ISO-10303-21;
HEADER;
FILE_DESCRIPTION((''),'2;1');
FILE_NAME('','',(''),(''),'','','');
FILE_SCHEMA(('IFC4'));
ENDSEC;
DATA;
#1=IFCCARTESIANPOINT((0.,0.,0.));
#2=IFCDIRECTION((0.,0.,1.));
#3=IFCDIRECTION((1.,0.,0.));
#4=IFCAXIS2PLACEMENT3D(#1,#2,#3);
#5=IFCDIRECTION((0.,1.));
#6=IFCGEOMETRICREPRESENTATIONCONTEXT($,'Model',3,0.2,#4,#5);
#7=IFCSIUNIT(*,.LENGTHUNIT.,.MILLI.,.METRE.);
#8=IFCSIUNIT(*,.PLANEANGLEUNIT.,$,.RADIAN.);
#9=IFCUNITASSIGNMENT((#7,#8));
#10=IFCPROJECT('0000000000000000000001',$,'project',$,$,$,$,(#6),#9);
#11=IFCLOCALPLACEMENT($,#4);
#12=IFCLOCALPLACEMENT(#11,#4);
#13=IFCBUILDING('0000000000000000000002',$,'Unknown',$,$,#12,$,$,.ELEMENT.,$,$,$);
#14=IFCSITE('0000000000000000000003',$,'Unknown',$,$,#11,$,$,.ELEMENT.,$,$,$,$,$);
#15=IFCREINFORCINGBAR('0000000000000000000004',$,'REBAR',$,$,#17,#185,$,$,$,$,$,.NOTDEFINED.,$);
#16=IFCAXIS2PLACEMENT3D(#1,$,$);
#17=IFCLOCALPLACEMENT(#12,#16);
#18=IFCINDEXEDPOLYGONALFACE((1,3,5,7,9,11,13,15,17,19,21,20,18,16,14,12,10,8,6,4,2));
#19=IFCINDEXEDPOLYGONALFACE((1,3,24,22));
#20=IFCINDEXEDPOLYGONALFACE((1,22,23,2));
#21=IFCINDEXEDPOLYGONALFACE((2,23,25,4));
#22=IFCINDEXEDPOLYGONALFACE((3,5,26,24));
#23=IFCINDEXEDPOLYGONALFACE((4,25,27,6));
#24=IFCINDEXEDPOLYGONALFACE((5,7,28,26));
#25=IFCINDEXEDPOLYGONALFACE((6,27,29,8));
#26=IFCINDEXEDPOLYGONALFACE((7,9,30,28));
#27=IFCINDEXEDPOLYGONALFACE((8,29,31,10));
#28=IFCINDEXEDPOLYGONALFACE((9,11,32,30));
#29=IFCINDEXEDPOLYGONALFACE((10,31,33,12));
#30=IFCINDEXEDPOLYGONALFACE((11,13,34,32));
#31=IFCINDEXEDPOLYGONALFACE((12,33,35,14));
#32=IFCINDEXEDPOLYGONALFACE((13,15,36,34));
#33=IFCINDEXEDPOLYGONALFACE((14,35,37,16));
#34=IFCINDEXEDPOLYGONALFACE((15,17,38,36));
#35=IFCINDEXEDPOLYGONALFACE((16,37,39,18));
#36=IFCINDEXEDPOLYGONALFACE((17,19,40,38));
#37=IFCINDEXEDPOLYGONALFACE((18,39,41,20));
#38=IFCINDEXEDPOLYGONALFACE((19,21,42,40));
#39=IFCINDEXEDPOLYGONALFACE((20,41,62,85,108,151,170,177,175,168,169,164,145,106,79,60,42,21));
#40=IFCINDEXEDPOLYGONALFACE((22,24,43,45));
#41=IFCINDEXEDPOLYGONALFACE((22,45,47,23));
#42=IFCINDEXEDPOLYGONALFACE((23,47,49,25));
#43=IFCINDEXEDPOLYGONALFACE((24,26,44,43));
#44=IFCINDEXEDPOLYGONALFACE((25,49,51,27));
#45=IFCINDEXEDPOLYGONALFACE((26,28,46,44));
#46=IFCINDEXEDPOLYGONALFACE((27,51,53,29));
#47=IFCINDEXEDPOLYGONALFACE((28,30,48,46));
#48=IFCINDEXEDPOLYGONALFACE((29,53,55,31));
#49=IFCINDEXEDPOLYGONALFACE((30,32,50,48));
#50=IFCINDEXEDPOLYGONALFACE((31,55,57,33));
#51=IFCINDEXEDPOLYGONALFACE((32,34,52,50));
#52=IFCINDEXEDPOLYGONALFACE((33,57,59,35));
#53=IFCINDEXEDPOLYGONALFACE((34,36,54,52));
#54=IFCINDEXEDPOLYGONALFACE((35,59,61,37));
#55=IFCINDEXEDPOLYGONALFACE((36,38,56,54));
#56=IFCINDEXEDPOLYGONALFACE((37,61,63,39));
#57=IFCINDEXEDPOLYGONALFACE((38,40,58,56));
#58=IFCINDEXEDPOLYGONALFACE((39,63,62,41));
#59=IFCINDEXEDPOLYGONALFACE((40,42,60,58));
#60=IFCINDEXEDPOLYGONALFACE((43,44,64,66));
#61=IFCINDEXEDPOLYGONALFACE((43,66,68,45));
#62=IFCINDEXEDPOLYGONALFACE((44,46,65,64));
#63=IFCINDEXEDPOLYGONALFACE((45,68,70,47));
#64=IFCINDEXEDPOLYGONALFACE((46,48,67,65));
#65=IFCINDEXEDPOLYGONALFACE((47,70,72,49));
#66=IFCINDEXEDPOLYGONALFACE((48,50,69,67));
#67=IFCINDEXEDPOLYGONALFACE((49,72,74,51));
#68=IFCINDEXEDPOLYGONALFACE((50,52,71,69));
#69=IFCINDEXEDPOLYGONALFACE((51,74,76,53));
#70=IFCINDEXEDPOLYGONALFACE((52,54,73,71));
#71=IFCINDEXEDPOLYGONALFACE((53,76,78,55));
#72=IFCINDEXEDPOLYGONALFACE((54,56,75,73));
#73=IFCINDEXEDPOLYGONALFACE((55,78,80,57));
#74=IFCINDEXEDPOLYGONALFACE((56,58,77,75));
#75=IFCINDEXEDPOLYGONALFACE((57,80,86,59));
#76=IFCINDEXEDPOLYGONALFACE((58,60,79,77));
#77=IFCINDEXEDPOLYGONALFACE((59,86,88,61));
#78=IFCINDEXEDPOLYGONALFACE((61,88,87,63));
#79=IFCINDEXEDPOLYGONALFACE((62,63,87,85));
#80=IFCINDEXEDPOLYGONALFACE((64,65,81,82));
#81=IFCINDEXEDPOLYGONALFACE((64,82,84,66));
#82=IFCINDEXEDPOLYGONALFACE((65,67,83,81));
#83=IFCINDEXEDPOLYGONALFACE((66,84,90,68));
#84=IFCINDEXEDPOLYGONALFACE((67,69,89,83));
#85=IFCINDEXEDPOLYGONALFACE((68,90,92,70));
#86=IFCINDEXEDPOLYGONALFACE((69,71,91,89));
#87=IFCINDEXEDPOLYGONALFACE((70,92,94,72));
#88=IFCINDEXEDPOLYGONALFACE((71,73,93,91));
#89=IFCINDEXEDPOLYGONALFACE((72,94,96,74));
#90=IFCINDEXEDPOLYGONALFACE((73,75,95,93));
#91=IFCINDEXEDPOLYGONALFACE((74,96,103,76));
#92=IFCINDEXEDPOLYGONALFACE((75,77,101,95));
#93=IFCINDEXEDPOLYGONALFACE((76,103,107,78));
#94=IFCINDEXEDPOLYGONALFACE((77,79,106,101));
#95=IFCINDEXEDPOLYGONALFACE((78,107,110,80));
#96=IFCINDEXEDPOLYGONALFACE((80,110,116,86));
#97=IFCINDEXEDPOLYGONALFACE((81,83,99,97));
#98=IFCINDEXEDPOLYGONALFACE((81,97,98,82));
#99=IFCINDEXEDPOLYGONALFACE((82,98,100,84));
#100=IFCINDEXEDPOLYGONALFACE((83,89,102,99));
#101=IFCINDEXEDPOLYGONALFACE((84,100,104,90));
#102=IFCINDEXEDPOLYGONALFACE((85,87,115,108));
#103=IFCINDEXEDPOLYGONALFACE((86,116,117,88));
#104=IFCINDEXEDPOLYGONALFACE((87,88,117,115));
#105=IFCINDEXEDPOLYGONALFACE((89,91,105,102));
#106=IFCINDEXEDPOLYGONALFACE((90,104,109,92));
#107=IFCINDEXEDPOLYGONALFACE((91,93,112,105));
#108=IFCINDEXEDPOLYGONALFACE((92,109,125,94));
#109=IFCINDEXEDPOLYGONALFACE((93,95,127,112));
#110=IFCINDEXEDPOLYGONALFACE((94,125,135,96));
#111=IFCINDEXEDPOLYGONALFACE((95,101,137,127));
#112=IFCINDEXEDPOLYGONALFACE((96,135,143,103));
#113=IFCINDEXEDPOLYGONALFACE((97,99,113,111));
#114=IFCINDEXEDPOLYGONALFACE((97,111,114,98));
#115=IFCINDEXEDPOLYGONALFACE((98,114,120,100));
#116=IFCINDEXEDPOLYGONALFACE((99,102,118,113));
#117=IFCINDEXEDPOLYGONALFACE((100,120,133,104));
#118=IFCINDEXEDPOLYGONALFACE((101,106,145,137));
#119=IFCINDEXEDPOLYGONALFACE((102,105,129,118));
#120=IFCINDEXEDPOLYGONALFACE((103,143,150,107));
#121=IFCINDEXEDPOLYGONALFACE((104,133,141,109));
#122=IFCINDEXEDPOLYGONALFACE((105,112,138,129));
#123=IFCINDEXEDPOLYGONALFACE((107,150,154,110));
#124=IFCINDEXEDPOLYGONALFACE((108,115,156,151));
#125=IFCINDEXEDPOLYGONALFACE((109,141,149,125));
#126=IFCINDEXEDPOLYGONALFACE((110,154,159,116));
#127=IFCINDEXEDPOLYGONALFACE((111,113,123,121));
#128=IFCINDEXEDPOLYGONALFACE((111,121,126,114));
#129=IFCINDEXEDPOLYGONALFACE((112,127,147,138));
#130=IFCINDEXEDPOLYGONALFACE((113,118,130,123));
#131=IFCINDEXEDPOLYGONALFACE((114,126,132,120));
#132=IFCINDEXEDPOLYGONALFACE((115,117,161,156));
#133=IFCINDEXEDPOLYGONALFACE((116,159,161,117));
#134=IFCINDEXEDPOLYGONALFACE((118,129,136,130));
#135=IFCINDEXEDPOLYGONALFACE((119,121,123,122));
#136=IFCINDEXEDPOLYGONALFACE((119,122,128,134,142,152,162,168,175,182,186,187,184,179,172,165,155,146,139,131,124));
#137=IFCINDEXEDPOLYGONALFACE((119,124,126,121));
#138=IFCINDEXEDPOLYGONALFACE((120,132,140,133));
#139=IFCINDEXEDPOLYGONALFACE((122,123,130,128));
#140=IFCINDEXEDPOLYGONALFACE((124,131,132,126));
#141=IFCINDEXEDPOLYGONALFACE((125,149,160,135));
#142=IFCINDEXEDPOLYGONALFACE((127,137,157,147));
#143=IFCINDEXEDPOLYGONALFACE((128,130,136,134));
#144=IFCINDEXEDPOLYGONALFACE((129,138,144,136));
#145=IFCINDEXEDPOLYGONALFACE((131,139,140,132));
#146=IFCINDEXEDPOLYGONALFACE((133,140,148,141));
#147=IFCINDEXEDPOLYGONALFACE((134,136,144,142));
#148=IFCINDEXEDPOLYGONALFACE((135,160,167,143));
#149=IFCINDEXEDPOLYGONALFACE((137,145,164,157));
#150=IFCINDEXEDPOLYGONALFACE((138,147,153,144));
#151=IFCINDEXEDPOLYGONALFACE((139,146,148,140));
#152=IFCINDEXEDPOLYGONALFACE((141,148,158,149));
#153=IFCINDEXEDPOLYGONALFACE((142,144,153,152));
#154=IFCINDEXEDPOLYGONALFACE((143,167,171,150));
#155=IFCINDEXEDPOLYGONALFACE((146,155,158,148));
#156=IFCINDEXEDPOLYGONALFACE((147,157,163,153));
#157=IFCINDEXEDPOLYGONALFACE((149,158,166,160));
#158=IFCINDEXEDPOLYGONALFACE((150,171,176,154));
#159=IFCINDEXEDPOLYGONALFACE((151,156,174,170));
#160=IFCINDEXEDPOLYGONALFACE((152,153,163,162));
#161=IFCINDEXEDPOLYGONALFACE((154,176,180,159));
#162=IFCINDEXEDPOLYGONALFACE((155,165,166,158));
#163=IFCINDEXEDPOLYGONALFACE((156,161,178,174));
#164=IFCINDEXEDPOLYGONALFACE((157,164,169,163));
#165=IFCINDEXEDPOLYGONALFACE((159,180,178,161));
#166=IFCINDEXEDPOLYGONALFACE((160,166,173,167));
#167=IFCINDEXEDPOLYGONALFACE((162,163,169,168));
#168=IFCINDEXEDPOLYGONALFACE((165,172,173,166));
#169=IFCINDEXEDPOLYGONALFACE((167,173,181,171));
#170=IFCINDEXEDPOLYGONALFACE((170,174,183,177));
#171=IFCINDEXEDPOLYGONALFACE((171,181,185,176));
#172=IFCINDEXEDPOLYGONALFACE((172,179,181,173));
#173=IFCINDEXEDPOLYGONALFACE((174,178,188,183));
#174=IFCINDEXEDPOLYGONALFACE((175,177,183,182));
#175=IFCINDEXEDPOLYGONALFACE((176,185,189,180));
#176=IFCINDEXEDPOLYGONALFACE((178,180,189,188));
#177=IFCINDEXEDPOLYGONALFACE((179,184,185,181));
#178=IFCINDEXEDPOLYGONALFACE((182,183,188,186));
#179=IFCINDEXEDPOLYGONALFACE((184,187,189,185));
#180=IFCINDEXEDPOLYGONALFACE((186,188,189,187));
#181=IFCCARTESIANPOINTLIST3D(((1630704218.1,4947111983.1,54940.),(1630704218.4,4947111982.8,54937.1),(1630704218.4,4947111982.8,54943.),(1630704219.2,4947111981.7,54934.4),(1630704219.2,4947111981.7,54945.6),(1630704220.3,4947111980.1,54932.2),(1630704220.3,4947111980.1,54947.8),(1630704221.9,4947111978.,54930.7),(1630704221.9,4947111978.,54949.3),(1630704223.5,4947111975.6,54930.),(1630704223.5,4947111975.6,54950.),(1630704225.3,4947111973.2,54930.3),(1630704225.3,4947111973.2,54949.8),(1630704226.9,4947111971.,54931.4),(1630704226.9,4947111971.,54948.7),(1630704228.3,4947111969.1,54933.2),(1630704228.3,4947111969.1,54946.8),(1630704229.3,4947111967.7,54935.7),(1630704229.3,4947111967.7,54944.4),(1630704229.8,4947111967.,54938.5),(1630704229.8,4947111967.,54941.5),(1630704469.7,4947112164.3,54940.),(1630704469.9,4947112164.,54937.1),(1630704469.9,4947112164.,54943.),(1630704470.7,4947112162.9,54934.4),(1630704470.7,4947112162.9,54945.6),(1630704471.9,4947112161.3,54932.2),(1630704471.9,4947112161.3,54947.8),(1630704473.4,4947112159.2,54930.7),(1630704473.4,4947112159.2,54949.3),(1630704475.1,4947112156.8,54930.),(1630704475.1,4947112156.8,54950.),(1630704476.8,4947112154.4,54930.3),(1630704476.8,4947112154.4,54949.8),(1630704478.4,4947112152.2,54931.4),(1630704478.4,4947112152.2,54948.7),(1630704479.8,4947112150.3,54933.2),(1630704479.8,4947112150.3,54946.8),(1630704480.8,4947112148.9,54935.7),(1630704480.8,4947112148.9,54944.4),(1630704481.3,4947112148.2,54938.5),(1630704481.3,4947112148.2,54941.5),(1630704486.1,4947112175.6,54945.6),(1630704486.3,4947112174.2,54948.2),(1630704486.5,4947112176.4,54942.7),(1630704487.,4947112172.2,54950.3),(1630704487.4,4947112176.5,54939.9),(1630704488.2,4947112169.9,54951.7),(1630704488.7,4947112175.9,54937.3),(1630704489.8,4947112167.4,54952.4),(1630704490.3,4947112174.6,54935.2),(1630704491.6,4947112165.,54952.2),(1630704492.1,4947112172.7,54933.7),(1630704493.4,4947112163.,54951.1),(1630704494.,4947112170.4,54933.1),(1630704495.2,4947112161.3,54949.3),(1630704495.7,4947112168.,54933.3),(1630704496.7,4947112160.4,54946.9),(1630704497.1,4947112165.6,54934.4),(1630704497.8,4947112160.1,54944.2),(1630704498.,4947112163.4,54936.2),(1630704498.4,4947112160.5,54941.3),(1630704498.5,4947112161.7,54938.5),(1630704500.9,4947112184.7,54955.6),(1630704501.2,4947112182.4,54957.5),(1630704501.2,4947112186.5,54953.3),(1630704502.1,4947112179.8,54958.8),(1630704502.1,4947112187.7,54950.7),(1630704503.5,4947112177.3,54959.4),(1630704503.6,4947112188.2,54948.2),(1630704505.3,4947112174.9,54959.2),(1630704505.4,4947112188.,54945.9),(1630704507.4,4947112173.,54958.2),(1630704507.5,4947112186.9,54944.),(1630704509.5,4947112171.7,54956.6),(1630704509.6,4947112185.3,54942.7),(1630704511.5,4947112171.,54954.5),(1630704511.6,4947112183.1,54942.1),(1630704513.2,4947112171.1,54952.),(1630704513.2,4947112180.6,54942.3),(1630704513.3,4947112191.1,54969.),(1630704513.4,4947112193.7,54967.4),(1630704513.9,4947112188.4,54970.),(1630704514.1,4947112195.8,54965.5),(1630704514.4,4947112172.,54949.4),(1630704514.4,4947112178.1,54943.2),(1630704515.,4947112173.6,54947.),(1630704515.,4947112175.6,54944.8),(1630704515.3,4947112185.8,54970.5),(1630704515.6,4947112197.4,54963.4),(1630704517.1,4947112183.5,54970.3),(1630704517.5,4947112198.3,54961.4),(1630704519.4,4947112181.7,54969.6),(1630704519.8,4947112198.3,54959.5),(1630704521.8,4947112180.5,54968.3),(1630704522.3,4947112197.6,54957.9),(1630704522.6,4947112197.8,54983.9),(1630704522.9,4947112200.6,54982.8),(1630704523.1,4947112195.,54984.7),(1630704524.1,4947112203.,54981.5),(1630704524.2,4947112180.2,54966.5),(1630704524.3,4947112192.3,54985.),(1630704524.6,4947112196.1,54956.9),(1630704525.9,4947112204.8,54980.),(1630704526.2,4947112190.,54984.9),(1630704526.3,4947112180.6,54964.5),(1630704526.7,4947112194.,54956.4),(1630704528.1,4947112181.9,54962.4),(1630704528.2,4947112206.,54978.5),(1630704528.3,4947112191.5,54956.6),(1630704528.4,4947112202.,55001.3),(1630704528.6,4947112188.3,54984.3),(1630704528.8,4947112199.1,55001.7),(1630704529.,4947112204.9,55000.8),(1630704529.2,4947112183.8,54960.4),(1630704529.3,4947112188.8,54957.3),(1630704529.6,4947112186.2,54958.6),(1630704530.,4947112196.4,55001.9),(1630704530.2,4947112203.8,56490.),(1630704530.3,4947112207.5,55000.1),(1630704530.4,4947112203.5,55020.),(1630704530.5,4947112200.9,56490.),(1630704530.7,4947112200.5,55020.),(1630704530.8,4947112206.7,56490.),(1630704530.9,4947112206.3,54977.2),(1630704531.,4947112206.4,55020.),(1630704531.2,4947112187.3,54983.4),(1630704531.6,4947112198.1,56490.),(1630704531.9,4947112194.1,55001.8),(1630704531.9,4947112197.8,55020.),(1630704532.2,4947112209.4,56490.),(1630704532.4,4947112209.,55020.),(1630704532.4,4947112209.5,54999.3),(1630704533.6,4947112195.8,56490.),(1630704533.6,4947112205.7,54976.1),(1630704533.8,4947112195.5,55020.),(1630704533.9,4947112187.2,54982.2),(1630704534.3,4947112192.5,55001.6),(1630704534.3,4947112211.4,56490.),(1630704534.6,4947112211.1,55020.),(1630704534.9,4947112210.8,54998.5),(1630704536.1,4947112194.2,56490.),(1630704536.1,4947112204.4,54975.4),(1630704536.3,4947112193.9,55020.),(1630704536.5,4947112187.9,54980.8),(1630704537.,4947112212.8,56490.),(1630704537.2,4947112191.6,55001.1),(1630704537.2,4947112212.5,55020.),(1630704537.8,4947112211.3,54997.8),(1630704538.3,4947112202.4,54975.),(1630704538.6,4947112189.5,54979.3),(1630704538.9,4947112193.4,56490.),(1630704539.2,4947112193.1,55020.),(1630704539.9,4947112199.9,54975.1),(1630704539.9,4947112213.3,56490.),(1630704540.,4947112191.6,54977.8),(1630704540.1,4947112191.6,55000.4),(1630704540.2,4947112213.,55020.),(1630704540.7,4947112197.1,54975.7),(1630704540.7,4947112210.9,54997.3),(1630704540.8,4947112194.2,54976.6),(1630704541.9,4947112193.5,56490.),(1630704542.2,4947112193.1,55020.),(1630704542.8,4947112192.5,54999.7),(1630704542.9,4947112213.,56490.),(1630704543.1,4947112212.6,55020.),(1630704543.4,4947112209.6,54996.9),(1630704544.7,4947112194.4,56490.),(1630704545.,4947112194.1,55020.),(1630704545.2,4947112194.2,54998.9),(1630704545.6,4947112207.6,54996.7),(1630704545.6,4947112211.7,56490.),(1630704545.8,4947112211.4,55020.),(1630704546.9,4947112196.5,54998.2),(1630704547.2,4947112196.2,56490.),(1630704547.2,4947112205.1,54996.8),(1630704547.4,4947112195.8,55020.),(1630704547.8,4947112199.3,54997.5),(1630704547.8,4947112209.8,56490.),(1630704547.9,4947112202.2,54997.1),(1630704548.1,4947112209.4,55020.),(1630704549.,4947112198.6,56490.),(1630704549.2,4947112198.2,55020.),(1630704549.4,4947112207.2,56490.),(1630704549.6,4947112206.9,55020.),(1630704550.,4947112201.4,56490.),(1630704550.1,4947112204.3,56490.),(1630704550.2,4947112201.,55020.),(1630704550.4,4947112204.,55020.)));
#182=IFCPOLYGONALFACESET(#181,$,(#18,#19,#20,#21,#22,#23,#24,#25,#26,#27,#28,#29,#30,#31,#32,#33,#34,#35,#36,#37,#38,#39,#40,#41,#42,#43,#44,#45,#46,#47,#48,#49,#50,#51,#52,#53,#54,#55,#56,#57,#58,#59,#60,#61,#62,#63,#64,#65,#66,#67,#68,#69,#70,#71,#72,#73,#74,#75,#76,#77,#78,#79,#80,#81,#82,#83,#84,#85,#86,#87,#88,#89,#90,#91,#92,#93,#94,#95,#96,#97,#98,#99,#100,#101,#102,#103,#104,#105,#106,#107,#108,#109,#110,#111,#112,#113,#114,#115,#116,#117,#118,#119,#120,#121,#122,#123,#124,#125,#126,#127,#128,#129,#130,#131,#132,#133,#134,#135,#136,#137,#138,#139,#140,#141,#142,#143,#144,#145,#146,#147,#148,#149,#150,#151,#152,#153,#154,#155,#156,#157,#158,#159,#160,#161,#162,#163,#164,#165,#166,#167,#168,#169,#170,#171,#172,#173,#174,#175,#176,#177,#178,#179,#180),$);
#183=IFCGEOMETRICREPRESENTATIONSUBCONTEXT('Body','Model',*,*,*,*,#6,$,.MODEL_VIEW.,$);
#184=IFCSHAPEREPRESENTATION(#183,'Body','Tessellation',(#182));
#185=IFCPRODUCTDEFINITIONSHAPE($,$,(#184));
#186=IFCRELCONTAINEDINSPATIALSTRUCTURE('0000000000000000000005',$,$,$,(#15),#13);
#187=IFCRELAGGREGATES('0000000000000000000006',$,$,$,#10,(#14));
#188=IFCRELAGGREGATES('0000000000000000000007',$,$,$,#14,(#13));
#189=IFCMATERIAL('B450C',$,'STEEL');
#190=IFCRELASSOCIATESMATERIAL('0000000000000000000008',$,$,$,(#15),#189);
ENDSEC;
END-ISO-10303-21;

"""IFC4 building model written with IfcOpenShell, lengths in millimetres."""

from ifc_helpers import new_model, entity, si_unit, direction, frame, origin_with_axes, place, context, subcontext, project, spatial, material, element, save


model = new_model("IFC4")

# Units and contexts
model_context = context("Model", 3, precision=0.2, world=origin_with_axes(), true_north=direction((0.0, 1.0)))
body_context = subcontext(model_context, "Body", "Model", "MODEL_VIEW")
ifc_project = project(units=[si_unit("LENGTHUNIT", "METRE", prefix="MILLI"), si_unit("PLANEANGLEUNIT", "RADIAN")], contexts=[model_context])

# Site, building
site_placement = place(None, origin_with_axes())
site = spatial("IfcSite", under=ifc_project, at=site_placement, Name="Unknown", CompositionType="ELEMENT")
building_placement = place(site_placement, origin_with_axes())
building = spatial("IfcBuilding", under=site, at=building_placement, Name="Unknown", CompositionType="ELEMENT")

# Reinforcing bar
ifc_material = material(Name="B450C", Category="STEEL")
reinforcing_bar_1_placement = place(building_placement, frame((1630704551.8, 4947112272.8, 54890.0), z_axis=(0.58449, -0.811401, 0.0), x_axis=(0.0, 0.0, 1.0)))
element("IfcReinforcingBar", 1, at=reinforcing_bar_1_placement, inside=building, material=ifc_material, Name="REBAR", PredefinedType="NOTDEFINED", context=body_context, shape_type="AdvancedSweptSolid", body=[
    entity("IfcSweptDiskSolid", entity("IfcIndexedPolyCurve", entity("IfcCartesianPointList3D", [[50.0, 440.0, 50.0], [50.0, 130.0, 50.0], [73.4, 73.4, 50.0], [130.0, 50.0, 50.0], [1600.0, 50.0, 49.5]]), [entity("IfcLineIndex", [1, 2]), entity("IfcArcIndex", [2, 3, 4]), entity("IfcLineIndex", [4, 5])]), 10.0),
])

save(model, "model.ifc")
